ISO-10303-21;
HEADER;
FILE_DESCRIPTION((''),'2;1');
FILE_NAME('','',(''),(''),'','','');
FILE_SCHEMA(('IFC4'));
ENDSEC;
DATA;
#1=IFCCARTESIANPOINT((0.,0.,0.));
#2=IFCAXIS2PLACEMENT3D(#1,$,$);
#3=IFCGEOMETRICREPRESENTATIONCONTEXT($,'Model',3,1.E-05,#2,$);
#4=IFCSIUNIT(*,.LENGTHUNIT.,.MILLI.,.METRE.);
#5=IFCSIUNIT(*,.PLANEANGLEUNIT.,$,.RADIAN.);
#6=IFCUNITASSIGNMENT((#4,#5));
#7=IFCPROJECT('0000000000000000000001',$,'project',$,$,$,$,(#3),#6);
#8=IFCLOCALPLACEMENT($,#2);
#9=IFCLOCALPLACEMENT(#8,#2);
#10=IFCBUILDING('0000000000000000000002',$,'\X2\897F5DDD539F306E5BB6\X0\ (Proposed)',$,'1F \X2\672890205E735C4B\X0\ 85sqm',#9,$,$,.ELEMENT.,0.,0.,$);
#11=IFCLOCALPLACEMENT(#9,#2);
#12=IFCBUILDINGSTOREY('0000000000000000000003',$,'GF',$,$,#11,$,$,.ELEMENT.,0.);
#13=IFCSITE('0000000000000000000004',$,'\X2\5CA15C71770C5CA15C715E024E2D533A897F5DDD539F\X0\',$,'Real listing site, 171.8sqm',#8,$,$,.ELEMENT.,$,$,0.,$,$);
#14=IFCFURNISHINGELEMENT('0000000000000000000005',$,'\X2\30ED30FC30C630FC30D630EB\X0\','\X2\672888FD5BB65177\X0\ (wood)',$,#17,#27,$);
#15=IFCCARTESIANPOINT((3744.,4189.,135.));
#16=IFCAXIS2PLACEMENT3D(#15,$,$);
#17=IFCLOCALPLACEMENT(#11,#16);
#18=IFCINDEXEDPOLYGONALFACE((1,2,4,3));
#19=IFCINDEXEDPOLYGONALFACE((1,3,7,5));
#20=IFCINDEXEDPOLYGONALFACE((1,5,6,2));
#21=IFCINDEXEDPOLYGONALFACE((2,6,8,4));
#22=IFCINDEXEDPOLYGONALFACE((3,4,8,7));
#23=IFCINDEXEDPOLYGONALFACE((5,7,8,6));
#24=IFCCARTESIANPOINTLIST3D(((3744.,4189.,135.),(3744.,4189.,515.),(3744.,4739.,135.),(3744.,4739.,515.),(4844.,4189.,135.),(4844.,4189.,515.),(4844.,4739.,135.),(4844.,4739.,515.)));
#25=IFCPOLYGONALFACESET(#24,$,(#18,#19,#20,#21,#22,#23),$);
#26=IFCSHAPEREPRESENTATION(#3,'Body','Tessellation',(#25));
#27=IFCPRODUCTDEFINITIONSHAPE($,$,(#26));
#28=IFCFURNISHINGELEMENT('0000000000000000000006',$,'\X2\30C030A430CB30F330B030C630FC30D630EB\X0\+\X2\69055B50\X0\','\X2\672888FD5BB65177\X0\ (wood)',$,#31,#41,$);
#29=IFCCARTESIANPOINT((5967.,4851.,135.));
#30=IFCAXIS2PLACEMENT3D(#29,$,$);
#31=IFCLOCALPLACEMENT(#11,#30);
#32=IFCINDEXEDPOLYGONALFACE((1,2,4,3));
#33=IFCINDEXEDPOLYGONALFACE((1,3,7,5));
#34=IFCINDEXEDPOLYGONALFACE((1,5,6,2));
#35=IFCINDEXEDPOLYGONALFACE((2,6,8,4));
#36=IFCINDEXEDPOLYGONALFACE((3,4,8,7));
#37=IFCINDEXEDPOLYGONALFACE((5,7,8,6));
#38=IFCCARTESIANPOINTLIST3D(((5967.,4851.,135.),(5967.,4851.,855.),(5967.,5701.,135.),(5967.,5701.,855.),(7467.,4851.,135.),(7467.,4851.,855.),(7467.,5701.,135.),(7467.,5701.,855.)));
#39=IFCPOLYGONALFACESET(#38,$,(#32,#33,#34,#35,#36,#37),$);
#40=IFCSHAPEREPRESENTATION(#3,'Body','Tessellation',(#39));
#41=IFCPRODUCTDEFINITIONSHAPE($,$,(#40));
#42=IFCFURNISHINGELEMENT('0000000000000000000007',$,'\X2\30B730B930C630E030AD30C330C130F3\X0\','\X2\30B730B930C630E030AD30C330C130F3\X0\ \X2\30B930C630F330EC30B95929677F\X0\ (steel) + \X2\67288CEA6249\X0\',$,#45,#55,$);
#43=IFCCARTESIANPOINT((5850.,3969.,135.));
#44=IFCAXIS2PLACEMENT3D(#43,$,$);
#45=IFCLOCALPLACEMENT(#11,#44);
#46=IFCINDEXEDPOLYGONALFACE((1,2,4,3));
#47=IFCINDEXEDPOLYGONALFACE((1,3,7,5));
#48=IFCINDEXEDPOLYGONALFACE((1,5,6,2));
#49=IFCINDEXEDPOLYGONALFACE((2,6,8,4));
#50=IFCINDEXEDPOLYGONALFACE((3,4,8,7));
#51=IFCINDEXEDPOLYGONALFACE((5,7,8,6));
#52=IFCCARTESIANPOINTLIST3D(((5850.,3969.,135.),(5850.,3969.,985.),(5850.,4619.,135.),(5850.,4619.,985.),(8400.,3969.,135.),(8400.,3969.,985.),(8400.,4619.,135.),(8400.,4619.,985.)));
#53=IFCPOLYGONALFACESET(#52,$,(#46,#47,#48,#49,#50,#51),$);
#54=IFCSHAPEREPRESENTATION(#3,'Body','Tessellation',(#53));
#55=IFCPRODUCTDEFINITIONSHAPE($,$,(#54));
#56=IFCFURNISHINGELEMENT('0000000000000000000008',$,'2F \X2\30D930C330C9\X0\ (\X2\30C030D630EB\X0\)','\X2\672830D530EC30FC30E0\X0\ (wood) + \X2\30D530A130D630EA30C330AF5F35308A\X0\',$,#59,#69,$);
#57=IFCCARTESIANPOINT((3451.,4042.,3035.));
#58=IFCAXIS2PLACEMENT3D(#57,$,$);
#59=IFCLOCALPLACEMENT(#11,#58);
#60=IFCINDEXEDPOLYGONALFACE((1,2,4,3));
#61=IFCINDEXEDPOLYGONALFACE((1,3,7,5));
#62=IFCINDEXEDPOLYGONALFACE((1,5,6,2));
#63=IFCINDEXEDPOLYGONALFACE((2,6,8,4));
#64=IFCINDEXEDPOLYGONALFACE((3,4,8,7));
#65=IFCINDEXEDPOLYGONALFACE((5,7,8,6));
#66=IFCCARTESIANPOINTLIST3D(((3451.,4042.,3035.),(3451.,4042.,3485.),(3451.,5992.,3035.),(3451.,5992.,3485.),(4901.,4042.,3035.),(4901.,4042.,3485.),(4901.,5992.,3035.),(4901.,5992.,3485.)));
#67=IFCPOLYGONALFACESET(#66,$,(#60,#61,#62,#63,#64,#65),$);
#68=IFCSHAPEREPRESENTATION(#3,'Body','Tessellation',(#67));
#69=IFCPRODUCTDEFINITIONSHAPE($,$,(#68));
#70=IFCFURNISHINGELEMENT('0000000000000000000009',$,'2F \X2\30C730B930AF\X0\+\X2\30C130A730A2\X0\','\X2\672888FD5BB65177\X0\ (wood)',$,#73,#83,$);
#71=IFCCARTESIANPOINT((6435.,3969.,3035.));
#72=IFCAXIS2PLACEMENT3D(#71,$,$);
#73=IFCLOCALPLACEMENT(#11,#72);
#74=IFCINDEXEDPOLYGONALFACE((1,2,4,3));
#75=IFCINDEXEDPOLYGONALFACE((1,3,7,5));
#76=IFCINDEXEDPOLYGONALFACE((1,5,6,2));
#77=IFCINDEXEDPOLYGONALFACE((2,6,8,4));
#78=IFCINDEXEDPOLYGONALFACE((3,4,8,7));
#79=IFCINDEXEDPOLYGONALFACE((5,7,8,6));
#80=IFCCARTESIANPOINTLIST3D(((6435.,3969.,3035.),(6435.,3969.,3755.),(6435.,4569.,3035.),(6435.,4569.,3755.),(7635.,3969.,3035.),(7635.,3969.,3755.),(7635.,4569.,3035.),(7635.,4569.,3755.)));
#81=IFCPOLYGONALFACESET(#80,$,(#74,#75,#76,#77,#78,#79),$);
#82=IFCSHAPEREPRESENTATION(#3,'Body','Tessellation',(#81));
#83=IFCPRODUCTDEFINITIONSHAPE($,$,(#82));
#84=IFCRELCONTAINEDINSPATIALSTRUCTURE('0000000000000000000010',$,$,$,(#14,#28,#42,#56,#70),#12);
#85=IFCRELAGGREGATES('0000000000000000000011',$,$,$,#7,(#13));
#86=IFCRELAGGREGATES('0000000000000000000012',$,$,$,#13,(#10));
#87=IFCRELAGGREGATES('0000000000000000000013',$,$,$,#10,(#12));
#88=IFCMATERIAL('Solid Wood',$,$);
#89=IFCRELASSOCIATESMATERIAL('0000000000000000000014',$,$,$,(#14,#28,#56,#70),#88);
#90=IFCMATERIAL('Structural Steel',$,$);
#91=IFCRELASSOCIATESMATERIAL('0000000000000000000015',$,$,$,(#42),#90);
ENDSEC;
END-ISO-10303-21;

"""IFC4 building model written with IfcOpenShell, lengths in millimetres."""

from ifc_helpers import new_model, si_unit, frame, frame_2d, origin, place, context, project, spatial, rectangle, extrude, material, element, save


model = new_model("IFC4")

# Units and contexts
model_context = context("Model", 3, precision=1e-05, world=origin())
ifc_project = project(units=[si_unit("LENGTHUNIT", "METRE", prefix="MILLI"), si_unit("PLANEANGLEUNIT", "RADIAN")], contexts=[model_context])

# Site, building, storey
site_placement = place(None, origin())
site = spatial("IfcSite", under=ifc_project, at=site_placement, Name="岡山県岡山市中区西川原", ObjectType="Real listing site, 171.8sqm", CompositionType="ELEMENT", RefElevation=0.0)
building_placement = place(site_placement, origin())
building = spatial("IfcBuilding", under=site, at=building_placement, Name="西川原の家 (Proposed)", ObjectType="1F 木造平屋 85sqm", CompositionType="ELEMENT", ElevationOfRefHeight=0.0, ElevationOfTerrain=0.0)
storey_placement = place(building_placement, origin())
storey = spatial("IfcBuildingStorey", under=building, at=storey_placement, Name="GF", CompositionType="ELEMENT", Elevation=0.0)

# Shared definitions
ifc_material_1 = material(Name="Solid Wood")

# Shared definitions
ifc_material_2 = material(Name="Structural Steel")

# Furnishing elements
furnishing_1_placement = place(storey_placement, frame((3744.0, 4189.0, 135.0)))
element("IfcFurnishingElement", 1, at=furnishing_1_placement, inside=storey, material=ifc_material_1, Name="ローテーブル", Description="木製家具 (wood)", context=model_context, shape_type="SweptSolid", body=[
    extrude(rectangle(XDim=1100.0, YDim=550.0, at=frame_2d((550.0, 275.0))), frame((3744.0, 4189.0, 135.0)), (0.0, 0.0, 1.0), 380.0),
])
furnishing_2_placement = place(storey_placement, frame((5967.0, 4851.0, 135.0)))
element("IfcFurnishingElement", 2, at=furnishing_2_placement, inside=storey, material=ifc_material_1, Name="ダイニングテーブル+椅子", Description="木製家具 (wood)", context=model_context, shape_type="SweptSolid", body=[
    extrude(rectangle(XDim=1500.0, YDim=850.0, at=frame_2d((750.0, 425.0))), frame((5967.0, 4851.0, 135.0)), (0.0, 0.0, 1.0), 720.0),
])
furnishing_3_placement = place(storey_placement, frame((5850.0, 3969.0, 135.0)))
element("IfcFurnishingElement", 3, at=furnishing_3_placement, inside=storey, material=ifc_material_2, Name="システムキッチン", Description="システムキッチン ステンレス天板 (steel) + 木質扉", context=model_context, shape_type="SweptSolid", body=[
    extrude(rectangle(XDim=2550.0, YDim=650.0, at=frame_2d((1275.0, 325.0))), frame((5850.0, 3969.0, 135.0)), (0.0, 0.0, 1.0), 850.0),
])
furnishing_4_placement = place(storey_placement, frame((3451.0, 4042.0, 3035.0)))
element("IfcFurnishingElement", 4, at=furnishing_4_placement, inside=storey, material=ifc_material_1, Name="2F ベッド (ダブル)", Description="木フレーム (wood) + ファブリック張り", context=model_context, shape_type="SweptSolid", body=[
    extrude(rectangle(XDim=1450.0, YDim=1950.0, at=frame_2d((725.0, 975.0))), frame((3451.0, 4042.0, 3035.0)), (0.0, 0.0, 1.0), 450.0),
])
furnishing_5_placement = place(storey_placement, frame((6435.0, 3969.0, 3035.0)))
element("IfcFurnishingElement", 5, at=furnishing_5_placement, inside=storey, material=ifc_material_1, Name="2F デスク+チェア", Description="木製家具 (wood)", context=model_context, shape_type="SweptSolid", body=[
    extrude(rectangle(XDim=1200.0, YDim=600.0, at=frame_2d((600.0, 300.0))), frame((6435.0, 3969.0, 3035.0)), (0.0, 0.0, 1.0), 720.0),
])

save(model, "model.ifc")
